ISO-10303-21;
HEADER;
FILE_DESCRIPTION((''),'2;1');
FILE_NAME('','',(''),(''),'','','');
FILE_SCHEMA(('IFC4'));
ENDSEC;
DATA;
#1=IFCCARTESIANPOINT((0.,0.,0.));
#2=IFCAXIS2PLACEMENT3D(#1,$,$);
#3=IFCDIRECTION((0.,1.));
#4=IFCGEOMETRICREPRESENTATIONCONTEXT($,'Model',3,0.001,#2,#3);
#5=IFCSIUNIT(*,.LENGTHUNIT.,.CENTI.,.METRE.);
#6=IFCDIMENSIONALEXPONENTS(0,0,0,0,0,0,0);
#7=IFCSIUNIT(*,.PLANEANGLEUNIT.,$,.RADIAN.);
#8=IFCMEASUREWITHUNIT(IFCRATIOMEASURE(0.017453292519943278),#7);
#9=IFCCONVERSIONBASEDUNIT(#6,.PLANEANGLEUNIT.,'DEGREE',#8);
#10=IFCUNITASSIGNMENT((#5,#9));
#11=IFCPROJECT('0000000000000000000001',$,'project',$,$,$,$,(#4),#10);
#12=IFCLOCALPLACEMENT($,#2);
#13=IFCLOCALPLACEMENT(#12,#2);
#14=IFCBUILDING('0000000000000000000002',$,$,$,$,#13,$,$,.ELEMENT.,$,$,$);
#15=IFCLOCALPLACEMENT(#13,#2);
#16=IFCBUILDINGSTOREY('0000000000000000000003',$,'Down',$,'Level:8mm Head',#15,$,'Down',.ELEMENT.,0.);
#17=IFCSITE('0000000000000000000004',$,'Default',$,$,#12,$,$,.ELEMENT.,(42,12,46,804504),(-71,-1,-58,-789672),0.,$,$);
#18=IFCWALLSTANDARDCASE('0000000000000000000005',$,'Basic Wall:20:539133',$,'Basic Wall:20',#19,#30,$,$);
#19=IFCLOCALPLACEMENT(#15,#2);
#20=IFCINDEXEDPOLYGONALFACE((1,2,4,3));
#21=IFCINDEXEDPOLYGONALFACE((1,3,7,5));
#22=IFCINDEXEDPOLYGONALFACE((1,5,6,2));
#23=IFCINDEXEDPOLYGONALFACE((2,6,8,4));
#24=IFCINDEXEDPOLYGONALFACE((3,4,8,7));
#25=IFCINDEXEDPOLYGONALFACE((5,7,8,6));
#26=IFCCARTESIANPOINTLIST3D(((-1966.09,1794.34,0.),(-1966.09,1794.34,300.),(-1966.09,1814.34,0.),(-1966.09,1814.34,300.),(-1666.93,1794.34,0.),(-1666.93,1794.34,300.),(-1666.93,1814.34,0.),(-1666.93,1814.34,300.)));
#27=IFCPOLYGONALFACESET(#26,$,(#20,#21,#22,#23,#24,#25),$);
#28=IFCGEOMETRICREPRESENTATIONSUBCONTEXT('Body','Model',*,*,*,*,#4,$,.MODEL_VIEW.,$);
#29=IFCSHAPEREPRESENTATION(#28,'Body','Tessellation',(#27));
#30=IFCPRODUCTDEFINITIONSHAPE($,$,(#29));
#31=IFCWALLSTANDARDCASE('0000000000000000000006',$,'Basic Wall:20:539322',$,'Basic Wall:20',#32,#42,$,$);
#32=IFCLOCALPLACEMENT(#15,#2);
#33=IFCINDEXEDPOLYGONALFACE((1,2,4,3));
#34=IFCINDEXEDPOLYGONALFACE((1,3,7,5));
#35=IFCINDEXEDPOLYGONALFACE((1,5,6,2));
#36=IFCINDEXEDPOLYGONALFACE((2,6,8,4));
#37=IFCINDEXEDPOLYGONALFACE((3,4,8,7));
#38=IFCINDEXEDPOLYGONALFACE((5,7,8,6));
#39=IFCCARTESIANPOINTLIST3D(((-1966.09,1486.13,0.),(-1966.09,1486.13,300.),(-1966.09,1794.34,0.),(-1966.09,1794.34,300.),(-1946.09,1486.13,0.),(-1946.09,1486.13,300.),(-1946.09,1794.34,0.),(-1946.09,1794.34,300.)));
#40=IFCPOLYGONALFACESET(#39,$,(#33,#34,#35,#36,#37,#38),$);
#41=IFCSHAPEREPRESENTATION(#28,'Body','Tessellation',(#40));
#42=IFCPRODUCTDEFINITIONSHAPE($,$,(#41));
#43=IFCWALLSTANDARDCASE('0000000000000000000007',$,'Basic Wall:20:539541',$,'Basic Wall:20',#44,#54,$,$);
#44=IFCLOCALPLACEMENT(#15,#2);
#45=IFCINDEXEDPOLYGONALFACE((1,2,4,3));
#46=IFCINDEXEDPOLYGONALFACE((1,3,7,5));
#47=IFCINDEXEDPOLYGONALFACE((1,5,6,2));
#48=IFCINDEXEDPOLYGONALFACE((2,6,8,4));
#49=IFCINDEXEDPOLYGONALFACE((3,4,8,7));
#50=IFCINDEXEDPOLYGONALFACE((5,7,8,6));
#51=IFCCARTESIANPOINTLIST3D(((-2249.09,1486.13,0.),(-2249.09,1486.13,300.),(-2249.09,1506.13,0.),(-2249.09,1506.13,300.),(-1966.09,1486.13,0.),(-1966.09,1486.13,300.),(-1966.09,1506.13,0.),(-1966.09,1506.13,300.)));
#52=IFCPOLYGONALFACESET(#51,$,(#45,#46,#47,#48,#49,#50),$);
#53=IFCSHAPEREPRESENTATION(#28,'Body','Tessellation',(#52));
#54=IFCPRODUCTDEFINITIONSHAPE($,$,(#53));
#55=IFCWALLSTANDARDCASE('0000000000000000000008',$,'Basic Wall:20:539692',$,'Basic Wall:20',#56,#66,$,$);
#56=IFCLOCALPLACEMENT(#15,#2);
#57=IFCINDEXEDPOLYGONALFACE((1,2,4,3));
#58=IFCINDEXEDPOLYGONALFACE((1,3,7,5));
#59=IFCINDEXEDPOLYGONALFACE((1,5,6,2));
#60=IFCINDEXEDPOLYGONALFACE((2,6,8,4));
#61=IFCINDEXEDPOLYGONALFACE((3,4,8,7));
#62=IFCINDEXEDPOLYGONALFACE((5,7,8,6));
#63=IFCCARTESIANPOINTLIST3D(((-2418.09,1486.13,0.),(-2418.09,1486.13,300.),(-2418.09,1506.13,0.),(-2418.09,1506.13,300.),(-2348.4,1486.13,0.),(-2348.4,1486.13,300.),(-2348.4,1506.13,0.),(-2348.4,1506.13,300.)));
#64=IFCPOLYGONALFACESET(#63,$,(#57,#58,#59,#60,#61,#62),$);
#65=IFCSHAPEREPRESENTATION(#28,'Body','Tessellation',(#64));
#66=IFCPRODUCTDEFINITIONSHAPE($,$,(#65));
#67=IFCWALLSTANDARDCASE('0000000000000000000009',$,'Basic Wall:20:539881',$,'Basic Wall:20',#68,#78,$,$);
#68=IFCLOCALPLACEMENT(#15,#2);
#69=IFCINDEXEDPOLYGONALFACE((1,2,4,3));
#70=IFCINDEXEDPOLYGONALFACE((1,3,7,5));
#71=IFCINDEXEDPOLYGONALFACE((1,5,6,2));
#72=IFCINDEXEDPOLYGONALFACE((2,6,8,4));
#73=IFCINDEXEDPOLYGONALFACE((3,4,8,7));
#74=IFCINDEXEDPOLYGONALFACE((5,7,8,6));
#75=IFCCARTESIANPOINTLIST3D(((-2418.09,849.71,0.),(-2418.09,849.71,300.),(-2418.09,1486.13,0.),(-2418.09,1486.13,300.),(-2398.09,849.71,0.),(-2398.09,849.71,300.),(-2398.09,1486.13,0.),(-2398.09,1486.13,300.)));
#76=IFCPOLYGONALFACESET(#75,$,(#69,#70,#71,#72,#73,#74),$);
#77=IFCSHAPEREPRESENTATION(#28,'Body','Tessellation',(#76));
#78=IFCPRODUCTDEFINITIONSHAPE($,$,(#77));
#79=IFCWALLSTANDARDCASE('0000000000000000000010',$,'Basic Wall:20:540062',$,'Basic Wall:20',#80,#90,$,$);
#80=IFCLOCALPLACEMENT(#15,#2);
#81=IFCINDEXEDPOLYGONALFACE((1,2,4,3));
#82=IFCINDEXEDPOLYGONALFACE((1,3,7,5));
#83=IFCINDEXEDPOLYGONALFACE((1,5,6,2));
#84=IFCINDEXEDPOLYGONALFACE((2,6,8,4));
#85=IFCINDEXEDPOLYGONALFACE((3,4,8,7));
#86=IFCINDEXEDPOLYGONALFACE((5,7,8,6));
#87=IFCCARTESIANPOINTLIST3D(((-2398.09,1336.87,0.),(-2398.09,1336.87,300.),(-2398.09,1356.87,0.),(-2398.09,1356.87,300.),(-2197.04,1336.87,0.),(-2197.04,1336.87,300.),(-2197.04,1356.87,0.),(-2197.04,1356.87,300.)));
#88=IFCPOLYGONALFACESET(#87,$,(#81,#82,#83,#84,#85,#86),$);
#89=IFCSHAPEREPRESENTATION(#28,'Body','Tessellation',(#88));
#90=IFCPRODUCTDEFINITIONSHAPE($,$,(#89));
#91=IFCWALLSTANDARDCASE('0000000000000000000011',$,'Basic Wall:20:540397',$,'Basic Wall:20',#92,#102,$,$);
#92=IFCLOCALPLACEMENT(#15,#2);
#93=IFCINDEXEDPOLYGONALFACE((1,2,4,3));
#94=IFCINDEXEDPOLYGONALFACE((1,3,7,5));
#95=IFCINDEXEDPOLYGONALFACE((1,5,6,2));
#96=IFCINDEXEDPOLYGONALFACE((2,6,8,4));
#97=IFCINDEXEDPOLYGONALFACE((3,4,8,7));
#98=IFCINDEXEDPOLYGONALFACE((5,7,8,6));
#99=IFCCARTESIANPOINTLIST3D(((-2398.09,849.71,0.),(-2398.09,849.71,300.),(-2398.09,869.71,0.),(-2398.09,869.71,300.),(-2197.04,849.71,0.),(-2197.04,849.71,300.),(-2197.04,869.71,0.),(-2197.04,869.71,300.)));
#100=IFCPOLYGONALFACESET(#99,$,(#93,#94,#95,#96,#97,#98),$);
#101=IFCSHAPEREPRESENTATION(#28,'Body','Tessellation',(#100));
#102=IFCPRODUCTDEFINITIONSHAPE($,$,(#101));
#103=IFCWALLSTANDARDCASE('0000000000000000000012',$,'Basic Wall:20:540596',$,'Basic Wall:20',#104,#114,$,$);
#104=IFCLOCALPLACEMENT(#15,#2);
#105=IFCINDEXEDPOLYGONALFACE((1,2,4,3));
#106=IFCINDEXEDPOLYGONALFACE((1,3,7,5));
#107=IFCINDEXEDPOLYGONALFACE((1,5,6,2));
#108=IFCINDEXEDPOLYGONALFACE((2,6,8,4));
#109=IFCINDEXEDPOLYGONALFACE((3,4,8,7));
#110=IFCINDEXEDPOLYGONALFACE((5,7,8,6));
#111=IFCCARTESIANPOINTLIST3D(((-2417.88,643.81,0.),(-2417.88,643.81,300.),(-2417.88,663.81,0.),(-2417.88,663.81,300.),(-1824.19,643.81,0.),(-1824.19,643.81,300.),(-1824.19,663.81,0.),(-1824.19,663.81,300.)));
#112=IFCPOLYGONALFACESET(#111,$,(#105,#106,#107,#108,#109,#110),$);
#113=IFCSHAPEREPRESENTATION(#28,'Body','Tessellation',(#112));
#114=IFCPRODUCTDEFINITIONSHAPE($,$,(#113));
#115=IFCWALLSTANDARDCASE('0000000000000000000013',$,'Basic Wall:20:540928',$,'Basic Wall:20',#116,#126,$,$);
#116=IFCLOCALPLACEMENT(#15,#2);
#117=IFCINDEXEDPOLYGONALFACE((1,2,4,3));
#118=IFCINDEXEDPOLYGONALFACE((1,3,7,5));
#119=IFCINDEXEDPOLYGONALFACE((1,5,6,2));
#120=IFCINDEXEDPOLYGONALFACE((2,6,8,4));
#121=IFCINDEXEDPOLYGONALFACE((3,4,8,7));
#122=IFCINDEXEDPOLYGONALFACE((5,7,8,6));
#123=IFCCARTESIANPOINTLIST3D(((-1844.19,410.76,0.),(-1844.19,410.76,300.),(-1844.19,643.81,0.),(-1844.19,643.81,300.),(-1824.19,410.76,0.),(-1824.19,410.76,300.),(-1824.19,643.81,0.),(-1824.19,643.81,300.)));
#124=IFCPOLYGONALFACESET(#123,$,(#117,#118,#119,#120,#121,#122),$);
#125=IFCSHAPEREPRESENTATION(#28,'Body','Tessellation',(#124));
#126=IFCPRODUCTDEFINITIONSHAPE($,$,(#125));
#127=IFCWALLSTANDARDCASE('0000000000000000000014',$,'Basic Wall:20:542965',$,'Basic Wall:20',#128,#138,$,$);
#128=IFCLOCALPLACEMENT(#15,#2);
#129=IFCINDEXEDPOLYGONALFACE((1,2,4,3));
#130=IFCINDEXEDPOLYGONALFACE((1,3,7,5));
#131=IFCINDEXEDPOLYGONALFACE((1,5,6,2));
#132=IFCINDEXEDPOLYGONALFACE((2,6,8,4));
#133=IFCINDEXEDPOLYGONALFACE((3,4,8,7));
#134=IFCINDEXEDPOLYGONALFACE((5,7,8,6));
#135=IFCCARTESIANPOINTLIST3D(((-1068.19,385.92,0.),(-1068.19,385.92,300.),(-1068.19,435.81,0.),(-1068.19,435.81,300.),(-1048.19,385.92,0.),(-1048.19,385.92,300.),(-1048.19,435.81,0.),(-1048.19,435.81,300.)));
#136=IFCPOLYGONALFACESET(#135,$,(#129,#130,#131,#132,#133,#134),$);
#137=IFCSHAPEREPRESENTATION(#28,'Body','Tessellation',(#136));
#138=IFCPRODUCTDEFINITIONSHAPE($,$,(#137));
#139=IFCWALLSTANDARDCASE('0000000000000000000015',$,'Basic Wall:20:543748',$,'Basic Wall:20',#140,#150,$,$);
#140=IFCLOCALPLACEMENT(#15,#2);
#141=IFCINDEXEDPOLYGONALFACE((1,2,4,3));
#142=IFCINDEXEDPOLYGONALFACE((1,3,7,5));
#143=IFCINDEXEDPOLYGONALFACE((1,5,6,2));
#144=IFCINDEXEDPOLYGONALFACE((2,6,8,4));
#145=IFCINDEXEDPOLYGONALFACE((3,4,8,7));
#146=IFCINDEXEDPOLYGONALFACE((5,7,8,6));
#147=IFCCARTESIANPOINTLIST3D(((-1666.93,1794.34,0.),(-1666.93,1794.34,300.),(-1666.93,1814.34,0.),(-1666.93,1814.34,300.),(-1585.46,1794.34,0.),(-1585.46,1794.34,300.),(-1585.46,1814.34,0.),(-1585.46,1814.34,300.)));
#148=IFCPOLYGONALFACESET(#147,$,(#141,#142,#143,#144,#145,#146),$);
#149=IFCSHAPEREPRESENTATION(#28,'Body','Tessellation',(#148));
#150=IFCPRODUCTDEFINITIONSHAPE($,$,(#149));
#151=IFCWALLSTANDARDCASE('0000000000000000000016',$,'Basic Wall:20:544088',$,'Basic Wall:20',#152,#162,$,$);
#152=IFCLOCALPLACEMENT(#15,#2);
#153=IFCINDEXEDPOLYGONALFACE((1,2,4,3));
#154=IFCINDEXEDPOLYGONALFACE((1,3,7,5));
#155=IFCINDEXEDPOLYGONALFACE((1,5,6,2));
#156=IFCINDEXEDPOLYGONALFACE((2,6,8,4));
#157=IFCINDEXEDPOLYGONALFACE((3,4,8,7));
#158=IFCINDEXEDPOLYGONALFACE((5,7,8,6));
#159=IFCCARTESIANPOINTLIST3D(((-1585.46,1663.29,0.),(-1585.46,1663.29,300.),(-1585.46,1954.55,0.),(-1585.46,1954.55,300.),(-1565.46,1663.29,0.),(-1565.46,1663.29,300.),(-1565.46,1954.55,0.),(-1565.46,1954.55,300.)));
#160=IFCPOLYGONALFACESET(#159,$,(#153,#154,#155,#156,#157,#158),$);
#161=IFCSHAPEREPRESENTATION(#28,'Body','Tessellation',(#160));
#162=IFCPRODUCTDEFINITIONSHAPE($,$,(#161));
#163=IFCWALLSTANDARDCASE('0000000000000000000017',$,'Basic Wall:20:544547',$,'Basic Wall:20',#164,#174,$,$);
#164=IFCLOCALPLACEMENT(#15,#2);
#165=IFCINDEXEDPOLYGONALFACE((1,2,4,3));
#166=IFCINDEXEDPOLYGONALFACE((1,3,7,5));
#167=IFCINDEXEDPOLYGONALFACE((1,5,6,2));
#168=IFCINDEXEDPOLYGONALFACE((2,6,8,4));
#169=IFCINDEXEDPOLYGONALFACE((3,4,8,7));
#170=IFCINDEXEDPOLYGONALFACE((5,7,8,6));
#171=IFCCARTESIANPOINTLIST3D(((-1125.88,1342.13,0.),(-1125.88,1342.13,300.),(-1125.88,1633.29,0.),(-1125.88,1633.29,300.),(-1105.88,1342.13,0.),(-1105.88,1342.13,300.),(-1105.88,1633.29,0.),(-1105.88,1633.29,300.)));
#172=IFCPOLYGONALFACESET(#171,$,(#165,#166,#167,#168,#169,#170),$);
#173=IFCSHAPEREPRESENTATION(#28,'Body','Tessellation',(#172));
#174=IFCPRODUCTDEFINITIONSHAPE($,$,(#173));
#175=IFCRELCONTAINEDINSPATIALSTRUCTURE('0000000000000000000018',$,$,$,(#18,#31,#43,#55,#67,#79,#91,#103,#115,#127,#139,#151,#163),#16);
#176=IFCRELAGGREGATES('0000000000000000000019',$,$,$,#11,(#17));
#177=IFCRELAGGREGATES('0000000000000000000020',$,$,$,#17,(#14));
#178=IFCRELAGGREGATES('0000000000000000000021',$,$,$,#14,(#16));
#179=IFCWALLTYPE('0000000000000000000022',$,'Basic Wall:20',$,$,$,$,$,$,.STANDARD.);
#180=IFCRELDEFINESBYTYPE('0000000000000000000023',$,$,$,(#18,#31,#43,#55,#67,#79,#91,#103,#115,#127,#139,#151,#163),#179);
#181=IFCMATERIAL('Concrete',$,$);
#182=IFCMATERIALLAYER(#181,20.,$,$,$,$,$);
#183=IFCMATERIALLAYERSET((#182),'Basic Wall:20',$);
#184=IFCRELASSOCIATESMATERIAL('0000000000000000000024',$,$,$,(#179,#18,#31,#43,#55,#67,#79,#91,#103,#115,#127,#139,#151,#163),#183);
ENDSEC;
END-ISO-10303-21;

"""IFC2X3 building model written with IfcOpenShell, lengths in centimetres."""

from ifc_helpers import new_model, entity, si_unit, converted_unit, direction, frame, frame_2d, origin, place, context, subcontext, project, spatial, rectangle, extrude, material, layer, layer_set, layer_usage, type_object, element, save


model = new_model("IFC2X3")

# Units and contexts
model_context = context("Model", 3, precision=0.001, world=origin(), true_north=direction((0.0, 1.0)))
body_context = subcontext(model_context, "Body", "Model", "MODEL_VIEW")
ifc_project = project(units=[si_unit("LENGTHUNIT", "METRE", prefix="CENTI"), converted_unit("PLANEANGLEUNIT", "DEGREE", entity("IfcRatioMeasure", 0.017453292519943278), si_unit("PLANEANGLEUNIT", "RADIAN"), dimensions=[0, 0, 0, 0, 0, 0, 0])], contexts=[model_context])

# Site, building, storey
site_placement = place(None, origin())
site = spatial("IfcSite", under=ifc_project, at=site_placement, Name="Default", CompositionType="ELEMENT", RefLatitude=(42, 12, 46, 804504), RefLongitude=(-71, -1, -58, -789672), RefElevation=0.0)
building_placement = place(site_placement, origin())
building = spatial("IfcBuilding", under=site, at=building_placement, CompositionType="ELEMENT")
storey_placement = place(building_placement, origin())
storey = spatial("IfcBuildingStorey", under=building, at=storey_placement, Name="Down", ObjectType="Level:8mm Head", LongName="Down", CompositionType="ELEMENT", Elevation=0.0)

# Walls
ifc_material = material(Name="Concrete")
ifc_layer_1 = layer(ifc_material, 20.0)
ifc_layer_set_1 = layer_set([ifc_layer_1], Name="Basic Wall:20")
ifc_layer_usage_1 = layer_usage(ifc_layer_set_1, "AXIS2", "POSITIVE", -10.0)
wall_type_1 = type_object("IfcWallType", Name="Basic Wall:20", PredefinedType="STANDARD", material=ifc_layer_set_1)
wall_1_placement = place(storey_placement, frame((-1666.93, 1804.34, 0.0), z_axis=(0.0, 0.0, 1.0), x_axis=(-1.0, 0.0, 0.0)))
element("IfcWallStandardCase", 1, at=wall_1_placement, inside=storey, type_object=wall_type_1, material=ifc_layer_usage_1, Name="Basic Wall:20:539133", ObjectType="Basic Wall:20", context=body_context, shape_type="SweptSolid", body=[
    extrude(rectangle(XDim=299.16, YDim=20.0, at=frame_2d((149.58, 0.0), x_axis=(-1.0, 0.0))), origin(), (0.0, 0.0, 1.0), 300.0),
])
ifc_layer_usage_2 = layer_usage(ifc_layer_set_1, "AXIS2", "POSITIVE", -10.0)
wall_2_placement = place(storey_placement, frame((-1956.09, 1794.34, 0.0), z_axis=(0.0, 0.0, 1.0), x_axis=(0.0, -1.0, 0.0)))
element("IfcWallStandardCase", 2, at=wall_2_placement, inside=storey, type_object=wall_type_1, material=ifc_layer_usage_2, Name="Basic Wall:20:539322", ObjectType="Basic Wall:20", context=body_context, shape_type="SweptSolid", body=[
    extrude(rectangle(XDim=308.21, YDim=20.0, at=frame_2d((154.11, 0.0), x_axis=(-1.0, 0.0))), origin(), (0.0, 0.0, 1.0), 300.0),
])
ifc_layer_usage_3 = layer_usage(ifc_layer_set_1, "AXIS2", "NEGATIVE", 10.0)
wall_3_placement = place(storey_placement, frame((-1966.09, 1496.13, 0.0), z_axis=(0.0, 0.0, 1.0), x_axis=(-1.0, 0.0, 0.0)))
element("IfcWallStandardCase", 3, at=wall_3_placement, inside=storey, type_object=wall_type_1, material=ifc_layer_usage_3, Name="Basic Wall:20:539541", ObjectType="Basic Wall:20", context=body_context, shape_type="SweptSolid", body=[
    extrude(rectangle(XDim=283.0, YDim=20.0, at=frame_2d((141.5, 0.0), x_axis=(-1.0, 0.0))), origin(), (0.0, 0.0, 1.0), 300.0),
])
ifc_layer_usage_4 = layer_usage(ifc_layer_set_1, "AXIS2", "NEGATIVE", 10.0)
wall_4_placement = place(storey_placement, frame((-2348.4, 1496.13, 0.0), z_axis=(0.0, 0.0, 1.0), x_axis=(-1.0, 0.0, 0.0)))
element("IfcWallStandardCase", 4, at=wall_4_placement, inside=storey, type_object=wall_type_1, material=ifc_layer_usage_4, Name="Basic Wall:20:539692", ObjectType="Basic Wall:20", context=body_context, shape_type="SweptSolid", body=[
    extrude(rectangle(XDim=69.68, YDim=20.0, at=frame_2d((34.84, 0.0), x_axis=(-1.0, 0.0))), origin(), (0.0, 0.0, 1.0), 300.0),
])
ifc_layer_usage_5 = layer_usage(ifc_layer_set_1, "AXIS2", "NEGATIVE", 10.0)
wall_5_placement = place(storey_placement, frame((-2408.09, 1486.13, 0.0), z_axis=(0.0, 0.0, 1.0), x_axis=(0.0, -1.0, 0.0)))
element("IfcWallStandardCase", 5, at=wall_5_placement, inside=storey, type_object=wall_type_1, material=ifc_layer_usage_5, Name="Basic Wall:20:539881", ObjectType="Basic Wall:20", context=body_context, shape_type="SweptSolid", body=[
    extrude(rectangle(XDim=636.42, YDim=20.0, at=frame_2d((318.21, 0.0), x_axis=(-1.0, 0.0))), origin(), (0.0, 0.0, 1.0), 300.0),
])
ifc_layer_usage_6 = layer_usage(ifc_layer_set_1, "AXIS2", "POSITIVE", -10.0)
wall_6_placement = place(storey_placement, frame((-2398.09, 1346.87, 0.0)))
element("IfcWallStandardCase", 6, at=wall_6_placement, inside=storey, type_object=wall_type_1, material=ifc_layer_usage_6, Name="Basic Wall:20:540062", ObjectType="Basic Wall:20", context=body_context, shape_type="SweptSolid", body=[
    extrude(rectangle(XDim=201.05, YDim=20.0, at=frame_2d((100.53, 0.0), x_axis=(-1.0, 0.0))), origin(), (0.0, 0.0, 1.0), 300.0),
])
ifc_layer_usage_7 = layer_usage(ifc_layer_set_1, "AXIS2", "POSITIVE", -10.0)
wall_7_placement = place(storey_placement, frame((-2398.09, 859.71, 0.0)))
element("IfcWallStandardCase", 7, at=wall_7_placement, inside=storey, type_object=wall_type_1, material=ifc_layer_usage_7, Name="Basic Wall:20:540397", ObjectType="Basic Wall:20", context=body_context, shape_type="SweptSolid", body=[
    extrude(rectangle(XDim=201.05, YDim=20.0, at=frame_2d((100.53, 0.0), x_axis=(-1.0, 0.0))), origin(), (0.0, 0.0, 1.0), 300.0),
])
ifc_layer_usage_8 = layer_usage(ifc_layer_set_1, "AXIS2", "POSITIVE", -10.0)
wall_8_placement = place(storey_placement, frame((-2417.88, 653.81, 0.0)))
element("IfcWallStandardCase", 8, at=wall_8_placement, inside=storey, type_object=wall_type_1, material=ifc_layer_usage_8, Name="Basic Wall:20:540596", ObjectType="Basic Wall:20", context=body_context, shape_type="SweptSolid", body=[
    extrude(rectangle(XDim=593.68, YDim=20.0, at=frame_2d((296.84, 0.0), x_axis=(-1.0, 0.0))), origin(), (0.0, 0.0, 1.0), 300.0),
])
ifc_layer_usage_9 = layer_usage(ifc_layer_set_1, "AXIS2", "NEGATIVE", 10.0)
wall_9_placement = place(storey_placement, frame((-1834.19, 643.81, 0.0), z_axis=(0.0, 0.0, 1.0), x_axis=(0.0, -1.0, 0.0)))
element("IfcWallStandardCase", 9, at=wall_9_placement, inside=storey, type_object=wall_type_1, material=ifc_layer_usage_9, Name="Basic Wall:20:540928", ObjectType="Basic Wall:20", context=body_context, shape_type="SweptSolid", body=[
    extrude(rectangle(XDim=233.05, YDim=20.0, at=frame_2d((116.53, 0.0), x_axis=(-1.0, 0.0))), origin(), (0.0, 0.0, 1.0), 300.0),
])
ifc_layer_usage_10 = layer_usage(ifc_layer_set_1, "AXIS2", "NEGATIVE", 10.0)
wall_10_placement = place(storey_placement, frame((-1058.19, 385.92, 0.0), z_axis=(0.0, 0.0, 1.0), x_axis=(0.0, 1.0, 0.0)))
element("IfcWallStandardCase", 10, at=wall_10_placement, inside=storey, type_object=wall_type_1, material=ifc_layer_usage_10, Name="Basic Wall:20:542965", ObjectType="Basic Wall:20", context=body_context, shape_type="SweptSolid", body=[
    extrude(rectangle(XDim=49.89, YDim=20.0, at=frame_2d((24.95, 0.0), x_axis=(-1.0, 0.0))), origin(), (0.0, 0.0, 1.0), 300.0),
])
ifc_layer_usage_11 = layer_usage(ifc_layer_set_1, "AXIS2", "POSITIVE", -10.0)
wall_11_placement = place(storey_placement, frame((-1666.93, 1804.34, 0.0)))
element("IfcWallStandardCase", 11, at=wall_11_placement, inside=storey, type_object=wall_type_1, material=ifc_layer_usage_11, Name="Basic Wall:20:543748", ObjectType="Basic Wall:20", context=body_context, shape_type="SweptSolid", body=[
    extrude(rectangle(XDim=81.47, YDim=20.0, at=frame_2d((40.74, 0.0), x_axis=(-1.0, 0.0))), origin(), (0.0, 0.0, 1.0), 300.0),
])
ifc_layer_usage_12 = layer_usage(ifc_layer_set_1, "AXIS2", "POSITIVE", -10.0)
wall_12_placement = place(storey_placement, frame((-1575.46, 1663.29, 0.0), z_axis=(0.0, 0.0, 1.0), x_axis=(0.0, 1.0, 0.0)))
element("IfcWallStandardCase", 12, at=wall_12_placement, inside=storey, type_object=wall_type_1, material=ifc_layer_usage_12, Name="Basic Wall:20:544088", ObjectType="Basic Wall:20", context=body_context, shape_type="SweptSolid", body=[
    extrude(rectangle(XDim=291.26, YDim=20.0, at=frame_2d((145.63, 0.0), x_axis=(-1.0, 0.0))), origin(), (0.0, 0.0, 1.0), 300.0),
])
ifc_layer_usage_13 = layer_usage(ifc_layer_set_1, "AXIS2", "NEGATIVE", 10.0)
wall_13_placement = place(storey_placement, frame((-1115.88, 1633.29, 0.0), z_axis=(0.0, 0.0, 1.0), x_axis=(0.0, -1.0, 0.0)))
element("IfcWallStandardCase", 13, at=wall_13_placement, inside=storey, type_object=wall_type_1, material=ifc_layer_usage_13, Name="Basic Wall:20:544547", ObjectType="Basic Wall:20", context=body_context, shape_type="SweptSolid", body=[
    extrude(rectangle(XDim=291.16, YDim=20.0, at=frame_2d((145.58, 0.0), x_axis=(-1.0, 0.0))), origin(), (0.0, 0.0, 1.0), 300.0),
])

save(model, "model.ifc")
